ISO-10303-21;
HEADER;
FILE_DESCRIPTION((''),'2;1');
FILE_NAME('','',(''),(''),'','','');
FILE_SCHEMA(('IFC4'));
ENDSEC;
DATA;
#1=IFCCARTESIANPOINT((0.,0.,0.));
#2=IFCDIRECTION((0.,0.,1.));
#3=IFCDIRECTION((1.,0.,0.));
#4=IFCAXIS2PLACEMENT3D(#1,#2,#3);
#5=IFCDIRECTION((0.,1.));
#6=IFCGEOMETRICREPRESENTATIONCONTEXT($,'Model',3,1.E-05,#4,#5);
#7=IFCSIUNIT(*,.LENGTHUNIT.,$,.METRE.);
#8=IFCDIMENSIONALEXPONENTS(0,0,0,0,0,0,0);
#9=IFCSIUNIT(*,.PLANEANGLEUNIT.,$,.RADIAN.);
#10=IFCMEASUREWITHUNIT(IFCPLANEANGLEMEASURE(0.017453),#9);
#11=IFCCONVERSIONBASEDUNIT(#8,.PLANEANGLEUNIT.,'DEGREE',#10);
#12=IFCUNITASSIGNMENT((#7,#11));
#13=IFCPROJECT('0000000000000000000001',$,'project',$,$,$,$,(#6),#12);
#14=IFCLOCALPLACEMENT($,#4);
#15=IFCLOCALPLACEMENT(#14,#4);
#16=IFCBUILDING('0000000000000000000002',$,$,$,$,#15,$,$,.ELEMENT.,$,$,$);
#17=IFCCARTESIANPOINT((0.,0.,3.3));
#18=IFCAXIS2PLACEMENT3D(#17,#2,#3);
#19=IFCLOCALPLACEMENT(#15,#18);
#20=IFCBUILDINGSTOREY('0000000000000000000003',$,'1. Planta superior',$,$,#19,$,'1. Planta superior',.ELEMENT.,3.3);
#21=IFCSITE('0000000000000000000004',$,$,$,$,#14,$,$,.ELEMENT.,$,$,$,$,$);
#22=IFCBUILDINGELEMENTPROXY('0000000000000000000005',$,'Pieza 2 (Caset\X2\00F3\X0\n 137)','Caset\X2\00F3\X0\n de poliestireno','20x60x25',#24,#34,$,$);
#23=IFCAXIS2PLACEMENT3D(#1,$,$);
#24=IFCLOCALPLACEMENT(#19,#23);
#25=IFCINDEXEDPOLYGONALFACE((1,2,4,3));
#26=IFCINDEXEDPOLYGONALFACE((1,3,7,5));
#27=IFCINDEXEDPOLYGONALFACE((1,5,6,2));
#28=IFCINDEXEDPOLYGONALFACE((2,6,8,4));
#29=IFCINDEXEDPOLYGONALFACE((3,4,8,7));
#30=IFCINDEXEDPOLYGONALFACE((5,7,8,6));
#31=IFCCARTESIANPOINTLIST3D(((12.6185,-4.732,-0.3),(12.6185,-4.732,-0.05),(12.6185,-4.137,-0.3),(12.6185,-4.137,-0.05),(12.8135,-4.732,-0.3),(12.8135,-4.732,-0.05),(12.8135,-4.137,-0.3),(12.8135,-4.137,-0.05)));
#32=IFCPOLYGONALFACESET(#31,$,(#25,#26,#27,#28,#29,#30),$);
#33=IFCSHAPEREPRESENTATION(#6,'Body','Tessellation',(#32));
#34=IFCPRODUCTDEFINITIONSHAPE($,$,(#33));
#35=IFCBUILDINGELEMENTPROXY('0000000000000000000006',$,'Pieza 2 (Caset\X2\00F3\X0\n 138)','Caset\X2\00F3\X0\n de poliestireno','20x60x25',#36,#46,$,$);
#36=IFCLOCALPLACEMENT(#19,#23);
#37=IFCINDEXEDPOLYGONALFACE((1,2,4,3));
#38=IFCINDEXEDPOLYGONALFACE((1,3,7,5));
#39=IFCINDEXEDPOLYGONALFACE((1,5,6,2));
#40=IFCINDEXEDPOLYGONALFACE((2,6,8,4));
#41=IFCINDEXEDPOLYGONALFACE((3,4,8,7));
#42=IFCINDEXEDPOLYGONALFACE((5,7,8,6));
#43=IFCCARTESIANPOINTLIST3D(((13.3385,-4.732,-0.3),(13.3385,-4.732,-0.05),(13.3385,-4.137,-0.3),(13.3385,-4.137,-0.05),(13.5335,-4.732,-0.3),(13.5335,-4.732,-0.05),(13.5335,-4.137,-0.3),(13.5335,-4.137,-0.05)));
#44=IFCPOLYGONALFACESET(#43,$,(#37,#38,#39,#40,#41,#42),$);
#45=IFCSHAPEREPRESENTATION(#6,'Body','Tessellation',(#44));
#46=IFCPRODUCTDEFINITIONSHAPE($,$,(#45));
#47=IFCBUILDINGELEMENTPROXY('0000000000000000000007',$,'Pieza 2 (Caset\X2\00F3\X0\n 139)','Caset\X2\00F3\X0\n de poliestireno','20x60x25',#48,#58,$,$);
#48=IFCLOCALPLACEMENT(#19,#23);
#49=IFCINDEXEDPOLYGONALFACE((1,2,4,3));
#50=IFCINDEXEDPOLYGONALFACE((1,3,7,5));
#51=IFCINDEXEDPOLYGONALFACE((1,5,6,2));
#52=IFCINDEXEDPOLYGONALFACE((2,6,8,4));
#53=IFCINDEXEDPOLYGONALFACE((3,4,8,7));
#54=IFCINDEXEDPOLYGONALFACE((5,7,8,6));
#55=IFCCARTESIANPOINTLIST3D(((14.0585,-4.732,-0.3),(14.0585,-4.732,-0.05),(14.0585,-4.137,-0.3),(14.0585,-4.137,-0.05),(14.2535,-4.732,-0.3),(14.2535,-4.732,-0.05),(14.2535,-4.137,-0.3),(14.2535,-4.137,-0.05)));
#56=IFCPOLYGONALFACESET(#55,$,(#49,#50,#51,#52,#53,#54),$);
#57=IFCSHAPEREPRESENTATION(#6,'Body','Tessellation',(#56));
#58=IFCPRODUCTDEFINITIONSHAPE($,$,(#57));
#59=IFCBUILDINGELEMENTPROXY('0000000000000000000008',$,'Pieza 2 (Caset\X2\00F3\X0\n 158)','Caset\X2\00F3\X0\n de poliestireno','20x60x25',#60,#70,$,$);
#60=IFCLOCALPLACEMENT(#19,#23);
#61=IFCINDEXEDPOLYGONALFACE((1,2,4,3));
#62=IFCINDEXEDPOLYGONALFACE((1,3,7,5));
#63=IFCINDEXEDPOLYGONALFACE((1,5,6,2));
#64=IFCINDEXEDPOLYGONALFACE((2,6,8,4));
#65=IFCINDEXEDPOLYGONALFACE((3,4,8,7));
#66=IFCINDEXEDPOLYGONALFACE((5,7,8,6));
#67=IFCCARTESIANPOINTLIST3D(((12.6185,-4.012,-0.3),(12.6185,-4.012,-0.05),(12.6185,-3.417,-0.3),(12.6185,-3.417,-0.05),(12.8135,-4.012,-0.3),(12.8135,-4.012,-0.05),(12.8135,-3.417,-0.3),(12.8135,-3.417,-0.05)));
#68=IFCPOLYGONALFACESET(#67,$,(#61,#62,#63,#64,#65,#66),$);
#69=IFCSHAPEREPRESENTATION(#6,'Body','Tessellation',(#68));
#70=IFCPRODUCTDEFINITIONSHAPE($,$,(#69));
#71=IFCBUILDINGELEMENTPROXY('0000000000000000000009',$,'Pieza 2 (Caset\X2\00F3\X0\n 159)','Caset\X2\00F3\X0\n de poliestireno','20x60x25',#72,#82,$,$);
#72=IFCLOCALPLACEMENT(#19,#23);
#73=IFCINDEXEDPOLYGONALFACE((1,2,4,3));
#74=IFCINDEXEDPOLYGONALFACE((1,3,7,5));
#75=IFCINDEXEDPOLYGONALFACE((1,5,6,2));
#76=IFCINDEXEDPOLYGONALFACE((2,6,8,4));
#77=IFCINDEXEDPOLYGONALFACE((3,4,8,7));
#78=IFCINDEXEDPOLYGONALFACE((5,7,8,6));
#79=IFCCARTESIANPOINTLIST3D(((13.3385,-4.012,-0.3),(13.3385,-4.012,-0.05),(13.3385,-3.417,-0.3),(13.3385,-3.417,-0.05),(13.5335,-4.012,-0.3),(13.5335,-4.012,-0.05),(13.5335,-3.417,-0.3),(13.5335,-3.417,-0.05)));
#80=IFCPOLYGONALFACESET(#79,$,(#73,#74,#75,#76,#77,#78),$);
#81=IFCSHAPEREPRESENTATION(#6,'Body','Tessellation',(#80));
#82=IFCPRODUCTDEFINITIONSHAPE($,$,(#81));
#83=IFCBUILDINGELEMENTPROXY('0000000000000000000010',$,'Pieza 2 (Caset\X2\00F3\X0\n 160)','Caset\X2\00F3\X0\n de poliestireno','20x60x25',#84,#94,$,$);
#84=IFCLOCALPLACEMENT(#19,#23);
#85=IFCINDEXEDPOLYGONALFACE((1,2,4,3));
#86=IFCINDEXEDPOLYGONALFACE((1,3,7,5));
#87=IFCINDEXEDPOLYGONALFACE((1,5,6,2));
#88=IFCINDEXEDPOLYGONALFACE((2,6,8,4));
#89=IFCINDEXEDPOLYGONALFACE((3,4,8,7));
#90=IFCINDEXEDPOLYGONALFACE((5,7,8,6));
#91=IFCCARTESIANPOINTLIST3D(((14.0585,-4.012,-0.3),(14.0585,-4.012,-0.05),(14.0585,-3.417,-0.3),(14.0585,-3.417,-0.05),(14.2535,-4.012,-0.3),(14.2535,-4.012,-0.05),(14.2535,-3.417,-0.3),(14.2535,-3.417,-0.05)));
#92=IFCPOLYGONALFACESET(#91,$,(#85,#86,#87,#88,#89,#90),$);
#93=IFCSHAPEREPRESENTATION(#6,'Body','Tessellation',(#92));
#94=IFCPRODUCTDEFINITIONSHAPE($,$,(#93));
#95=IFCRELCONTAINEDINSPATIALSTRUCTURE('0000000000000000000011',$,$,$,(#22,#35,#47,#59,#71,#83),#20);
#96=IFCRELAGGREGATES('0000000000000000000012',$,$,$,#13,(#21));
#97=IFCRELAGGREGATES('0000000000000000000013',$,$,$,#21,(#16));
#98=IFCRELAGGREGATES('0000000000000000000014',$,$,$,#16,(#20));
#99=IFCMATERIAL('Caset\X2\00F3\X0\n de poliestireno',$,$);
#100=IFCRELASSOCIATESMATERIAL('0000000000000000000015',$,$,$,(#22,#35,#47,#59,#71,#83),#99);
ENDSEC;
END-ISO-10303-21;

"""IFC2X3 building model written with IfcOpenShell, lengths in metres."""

from ifc_helpers import new_model, entity, si_unit, converted_unit, direction, frame, origin_with_axes, origin_2d_with_axis, place, context, project, spatial, rectangle, extrude, source, transform, mapped, material, element, save


model = new_model("IFC2X3")

# Units and contexts
model_context = context("Model", 3, precision=1e-05, world=origin_with_axes(), true_north=direction((0.0, 1.0)))
ifc_project = project(units=[si_unit("LENGTHUNIT", "METRE"), converted_unit("PLANEANGLEUNIT", "DEGREE", entity("IfcPlaneAngleMeasure", 0.017453), si_unit("PLANEANGLEUNIT", "RADIAN"), dimensions=[0, 0, 0, 0, 0, 0, 0])], contexts=[model_context])

# Site, building, storey
site_placement = place(None, origin_with_axes())
site = spatial("IfcSite", under=ifc_project, at=site_placement, CompositionType="ELEMENT")
building_placement = place(site_placement, origin_with_axes())
building = spatial("IfcBuilding", under=site, at=building_placement, CompositionType="ELEMENT")
storey_placement = place(building_placement, frame((0.0, 0.0, 3.3), z_axis=(0.0, 0.0, 1.0), x_axis=(1.0, 0.0, 0.0)))
storey = spatial("IfcBuildingStorey", under=building, at=storey_placement, Name="1. Planta superior", LongName="1. Planta superior", CompositionType="ELEMENT", Elevation=3.3)

# Building element proxies
ifc_material = material(Name="Casetón de poliestireno")
shared_shape = source(origin_with_axes(), model_context, "Body", "SweptSolid", [
    extrude(rectangle(XDim=0.195, YDim=0.25, at=origin_2d_with_axis()), origin_with_axes(), (0.0, 0.0, 1.0), 0.595),
])
placement_1 = place(storey_placement, frame((12.716, -4.732, -0.175), z_axis=(0.0, 1.0, 0.0), x_axis=(-1.0, 0.0, 0.0)))
for number, where, z_axis, x_axis, name in (
    (1, (0.0, 0.0, 0.0), (0.0, 0.0, 1.0), (1.0, 0.0, 0.0), "Pieza 2 (Casetón 137)"),
):
    element("IfcBuildingElementProxy", number, at=place(placement_1, frame(where, z_axis=z_axis, x_axis=x_axis)), inside=storey, material=ifc_material, Name=name, Description="Casetón de poliestireno", ObjectType="20x60x25", context=model_context, shape_type="MappedRepresentation", body=[
        mapped(shared_shape, transform((0.0, 0.0, 0.0), x_axis=(1.0, 0.0, 0.0), y_axis=(0.0, 1.0, 0.0), z_axis=(0.0, 0.0, 1.0))),
    ])
placement_2 = place(storey_placement, frame((13.436, -4.732, -0.175), z_axis=(0.0, 1.0, 0.0), x_axis=(-1.0, 0.0, 0.0)))
for number, where, z_axis, x_axis, name in (
    (2, (0.0, 0.0, 0.0), (0.0, 0.0, 1.0), (1.0, 0.0, 0.0), "Pieza 2 (Casetón 138)"),
):
    element("IfcBuildingElementProxy", number, at=place(placement_2, frame(where, z_axis=z_axis, x_axis=x_axis)), inside=storey, material=ifc_material, Name=name, Description="Casetón de poliestireno", ObjectType="20x60x25", context=model_context, shape_type="MappedRepresentation", body=[
        mapped(shared_shape, transform((0.0, 0.0, 0.0), x_axis=(1.0, 0.0, 0.0), y_axis=(0.0, 1.0, 0.0), z_axis=(0.0, 0.0, 1.0))),
    ])
placement_3 = place(storey_placement, frame((14.156, -4.732, -0.175), z_axis=(0.0, 1.0, 0.0), x_axis=(-1.0, 0.0, 0.0)))
for number, where, z_axis, x_axis, name in (
    (3, (0.0, 0.0, 0.0), (0.0, 0.0, 1.0), (1.0, 0.0, 0.0), "Pieza 2 (Casetón 139)"),
):
    element("IfcBuildingElementProxy", number, at=place(placement_3, frame(where, z_axis=z_axis, x_axis=x_axis)), inside=storey, material=ifc_material, Name=name, Description="Casetón de poliestireno", ObjectType="20x60x25", context=model_context, shape_type="MappedRepresentation", body=[
        mapped(shared_shape, transform((0.0, 0.0, 0.0), x_axis=(1.0, 0.0, 0.0), y_axis=(0.0, 1.0, 0.0), z_axis=(0.0, 0.0, 1.0))),
    ])
placement_4 = place(storey_placement, frame((12.716, -4.012, -0.175), z_axis=(0.0, 1.0, 0.0), x_axis=(-1.0, 0.0, 0.0)))
for number, where, z_axis, x_axis, name in (
    (4, (0.0, 0.0, 0.0), (0.0, 0.0, 1.0), (1.0, 0.0, 0.0), "Pieza 2 (Casetón 158)"),
):
    element("IfcBuildingElementProxy", number, at=place(placement_4, frame(where, z_axis=z_axis, x_axis=x_axis)), inside=storey, material=ifc_material, Name=name, Description="Casetón de poliestireno", ObjectType="20x60x25", context=model_context, shape_type="MappedRepresentation", body=[
        mapped(shared_shape, transform((0.0, 0.0, 0.0), x_axis=(1.0, 0.0, 0.0), y_axis=(0.0, 1.0, 0.0), z_axis=(0.0, 0.0, 1.0))),
    ])
placement_5 = place(storey_placement, frame((13.436, -4.012, -0.175), z_axis=(0.0, 1.0, 0.0), x_axis=(-1.0, 0.0, 0.0)))
for number, where, z_axis, x_axis, name in (
    (5, (0.0, 0.0, 0.0), (0.0, 0.0, 1.0), (1.0, 0.0, 0.0), "Pieza 2 (Casetón 159)"),
):
    element("IfcBuildingElementProxy", number, at=place(placement_5, frame(where, z_axis=z_axis, x_axis=x_axis)), inside=storey, material=ifc_material, Name=name, Description="Casetón de poliestireno", ObjectType="20x60x25", context=model_context, shape_type="MappedRepresentation", body=[
        mapped(shared_shape, transform((0.0, 0.0, 0.0), x_axis=(1.0, 0.0, 0.0), y_axis=(0.0, 1.0, 0.0), z_axis=(0.0, 0.0, 1.0))),
    ])
placement_6 = place(storey_placement, frame((14.156, -4.012, -0.175), z_axis=(0.0, 1.0, 0.0), x_axis=(-1.0, 0.0, 0.0)))
for number, where, z_axis, x_axis, name in (
    (6, (0.0, 0.0, 0.0), (0.0, 0.0, 1.0), (1.0, 0.0, 0.0), "Pieza 2 (Casetón 160)"),
):
    element("IfcBuildingElementProxy", number, at=place(placement_6, frame(where, z_axis=z_axis, x_axis=x_axis)), inside=storey, material=ifc_material, Name=name, Description="Casetón de poliestireno", ObjectType="20x60x25", context=model_context, shape_type="MappedRepresentation", body=[
        mapped(shared_shape, transform((0.0, 0.0, 0.0), x_axis=(1.0, 0.0, 0.0), y_axis=(0.0, 1.0, 0.0), z_axis=(0.0, 0.0, 1.0))),
    ])

save(model, "model.ifc")
